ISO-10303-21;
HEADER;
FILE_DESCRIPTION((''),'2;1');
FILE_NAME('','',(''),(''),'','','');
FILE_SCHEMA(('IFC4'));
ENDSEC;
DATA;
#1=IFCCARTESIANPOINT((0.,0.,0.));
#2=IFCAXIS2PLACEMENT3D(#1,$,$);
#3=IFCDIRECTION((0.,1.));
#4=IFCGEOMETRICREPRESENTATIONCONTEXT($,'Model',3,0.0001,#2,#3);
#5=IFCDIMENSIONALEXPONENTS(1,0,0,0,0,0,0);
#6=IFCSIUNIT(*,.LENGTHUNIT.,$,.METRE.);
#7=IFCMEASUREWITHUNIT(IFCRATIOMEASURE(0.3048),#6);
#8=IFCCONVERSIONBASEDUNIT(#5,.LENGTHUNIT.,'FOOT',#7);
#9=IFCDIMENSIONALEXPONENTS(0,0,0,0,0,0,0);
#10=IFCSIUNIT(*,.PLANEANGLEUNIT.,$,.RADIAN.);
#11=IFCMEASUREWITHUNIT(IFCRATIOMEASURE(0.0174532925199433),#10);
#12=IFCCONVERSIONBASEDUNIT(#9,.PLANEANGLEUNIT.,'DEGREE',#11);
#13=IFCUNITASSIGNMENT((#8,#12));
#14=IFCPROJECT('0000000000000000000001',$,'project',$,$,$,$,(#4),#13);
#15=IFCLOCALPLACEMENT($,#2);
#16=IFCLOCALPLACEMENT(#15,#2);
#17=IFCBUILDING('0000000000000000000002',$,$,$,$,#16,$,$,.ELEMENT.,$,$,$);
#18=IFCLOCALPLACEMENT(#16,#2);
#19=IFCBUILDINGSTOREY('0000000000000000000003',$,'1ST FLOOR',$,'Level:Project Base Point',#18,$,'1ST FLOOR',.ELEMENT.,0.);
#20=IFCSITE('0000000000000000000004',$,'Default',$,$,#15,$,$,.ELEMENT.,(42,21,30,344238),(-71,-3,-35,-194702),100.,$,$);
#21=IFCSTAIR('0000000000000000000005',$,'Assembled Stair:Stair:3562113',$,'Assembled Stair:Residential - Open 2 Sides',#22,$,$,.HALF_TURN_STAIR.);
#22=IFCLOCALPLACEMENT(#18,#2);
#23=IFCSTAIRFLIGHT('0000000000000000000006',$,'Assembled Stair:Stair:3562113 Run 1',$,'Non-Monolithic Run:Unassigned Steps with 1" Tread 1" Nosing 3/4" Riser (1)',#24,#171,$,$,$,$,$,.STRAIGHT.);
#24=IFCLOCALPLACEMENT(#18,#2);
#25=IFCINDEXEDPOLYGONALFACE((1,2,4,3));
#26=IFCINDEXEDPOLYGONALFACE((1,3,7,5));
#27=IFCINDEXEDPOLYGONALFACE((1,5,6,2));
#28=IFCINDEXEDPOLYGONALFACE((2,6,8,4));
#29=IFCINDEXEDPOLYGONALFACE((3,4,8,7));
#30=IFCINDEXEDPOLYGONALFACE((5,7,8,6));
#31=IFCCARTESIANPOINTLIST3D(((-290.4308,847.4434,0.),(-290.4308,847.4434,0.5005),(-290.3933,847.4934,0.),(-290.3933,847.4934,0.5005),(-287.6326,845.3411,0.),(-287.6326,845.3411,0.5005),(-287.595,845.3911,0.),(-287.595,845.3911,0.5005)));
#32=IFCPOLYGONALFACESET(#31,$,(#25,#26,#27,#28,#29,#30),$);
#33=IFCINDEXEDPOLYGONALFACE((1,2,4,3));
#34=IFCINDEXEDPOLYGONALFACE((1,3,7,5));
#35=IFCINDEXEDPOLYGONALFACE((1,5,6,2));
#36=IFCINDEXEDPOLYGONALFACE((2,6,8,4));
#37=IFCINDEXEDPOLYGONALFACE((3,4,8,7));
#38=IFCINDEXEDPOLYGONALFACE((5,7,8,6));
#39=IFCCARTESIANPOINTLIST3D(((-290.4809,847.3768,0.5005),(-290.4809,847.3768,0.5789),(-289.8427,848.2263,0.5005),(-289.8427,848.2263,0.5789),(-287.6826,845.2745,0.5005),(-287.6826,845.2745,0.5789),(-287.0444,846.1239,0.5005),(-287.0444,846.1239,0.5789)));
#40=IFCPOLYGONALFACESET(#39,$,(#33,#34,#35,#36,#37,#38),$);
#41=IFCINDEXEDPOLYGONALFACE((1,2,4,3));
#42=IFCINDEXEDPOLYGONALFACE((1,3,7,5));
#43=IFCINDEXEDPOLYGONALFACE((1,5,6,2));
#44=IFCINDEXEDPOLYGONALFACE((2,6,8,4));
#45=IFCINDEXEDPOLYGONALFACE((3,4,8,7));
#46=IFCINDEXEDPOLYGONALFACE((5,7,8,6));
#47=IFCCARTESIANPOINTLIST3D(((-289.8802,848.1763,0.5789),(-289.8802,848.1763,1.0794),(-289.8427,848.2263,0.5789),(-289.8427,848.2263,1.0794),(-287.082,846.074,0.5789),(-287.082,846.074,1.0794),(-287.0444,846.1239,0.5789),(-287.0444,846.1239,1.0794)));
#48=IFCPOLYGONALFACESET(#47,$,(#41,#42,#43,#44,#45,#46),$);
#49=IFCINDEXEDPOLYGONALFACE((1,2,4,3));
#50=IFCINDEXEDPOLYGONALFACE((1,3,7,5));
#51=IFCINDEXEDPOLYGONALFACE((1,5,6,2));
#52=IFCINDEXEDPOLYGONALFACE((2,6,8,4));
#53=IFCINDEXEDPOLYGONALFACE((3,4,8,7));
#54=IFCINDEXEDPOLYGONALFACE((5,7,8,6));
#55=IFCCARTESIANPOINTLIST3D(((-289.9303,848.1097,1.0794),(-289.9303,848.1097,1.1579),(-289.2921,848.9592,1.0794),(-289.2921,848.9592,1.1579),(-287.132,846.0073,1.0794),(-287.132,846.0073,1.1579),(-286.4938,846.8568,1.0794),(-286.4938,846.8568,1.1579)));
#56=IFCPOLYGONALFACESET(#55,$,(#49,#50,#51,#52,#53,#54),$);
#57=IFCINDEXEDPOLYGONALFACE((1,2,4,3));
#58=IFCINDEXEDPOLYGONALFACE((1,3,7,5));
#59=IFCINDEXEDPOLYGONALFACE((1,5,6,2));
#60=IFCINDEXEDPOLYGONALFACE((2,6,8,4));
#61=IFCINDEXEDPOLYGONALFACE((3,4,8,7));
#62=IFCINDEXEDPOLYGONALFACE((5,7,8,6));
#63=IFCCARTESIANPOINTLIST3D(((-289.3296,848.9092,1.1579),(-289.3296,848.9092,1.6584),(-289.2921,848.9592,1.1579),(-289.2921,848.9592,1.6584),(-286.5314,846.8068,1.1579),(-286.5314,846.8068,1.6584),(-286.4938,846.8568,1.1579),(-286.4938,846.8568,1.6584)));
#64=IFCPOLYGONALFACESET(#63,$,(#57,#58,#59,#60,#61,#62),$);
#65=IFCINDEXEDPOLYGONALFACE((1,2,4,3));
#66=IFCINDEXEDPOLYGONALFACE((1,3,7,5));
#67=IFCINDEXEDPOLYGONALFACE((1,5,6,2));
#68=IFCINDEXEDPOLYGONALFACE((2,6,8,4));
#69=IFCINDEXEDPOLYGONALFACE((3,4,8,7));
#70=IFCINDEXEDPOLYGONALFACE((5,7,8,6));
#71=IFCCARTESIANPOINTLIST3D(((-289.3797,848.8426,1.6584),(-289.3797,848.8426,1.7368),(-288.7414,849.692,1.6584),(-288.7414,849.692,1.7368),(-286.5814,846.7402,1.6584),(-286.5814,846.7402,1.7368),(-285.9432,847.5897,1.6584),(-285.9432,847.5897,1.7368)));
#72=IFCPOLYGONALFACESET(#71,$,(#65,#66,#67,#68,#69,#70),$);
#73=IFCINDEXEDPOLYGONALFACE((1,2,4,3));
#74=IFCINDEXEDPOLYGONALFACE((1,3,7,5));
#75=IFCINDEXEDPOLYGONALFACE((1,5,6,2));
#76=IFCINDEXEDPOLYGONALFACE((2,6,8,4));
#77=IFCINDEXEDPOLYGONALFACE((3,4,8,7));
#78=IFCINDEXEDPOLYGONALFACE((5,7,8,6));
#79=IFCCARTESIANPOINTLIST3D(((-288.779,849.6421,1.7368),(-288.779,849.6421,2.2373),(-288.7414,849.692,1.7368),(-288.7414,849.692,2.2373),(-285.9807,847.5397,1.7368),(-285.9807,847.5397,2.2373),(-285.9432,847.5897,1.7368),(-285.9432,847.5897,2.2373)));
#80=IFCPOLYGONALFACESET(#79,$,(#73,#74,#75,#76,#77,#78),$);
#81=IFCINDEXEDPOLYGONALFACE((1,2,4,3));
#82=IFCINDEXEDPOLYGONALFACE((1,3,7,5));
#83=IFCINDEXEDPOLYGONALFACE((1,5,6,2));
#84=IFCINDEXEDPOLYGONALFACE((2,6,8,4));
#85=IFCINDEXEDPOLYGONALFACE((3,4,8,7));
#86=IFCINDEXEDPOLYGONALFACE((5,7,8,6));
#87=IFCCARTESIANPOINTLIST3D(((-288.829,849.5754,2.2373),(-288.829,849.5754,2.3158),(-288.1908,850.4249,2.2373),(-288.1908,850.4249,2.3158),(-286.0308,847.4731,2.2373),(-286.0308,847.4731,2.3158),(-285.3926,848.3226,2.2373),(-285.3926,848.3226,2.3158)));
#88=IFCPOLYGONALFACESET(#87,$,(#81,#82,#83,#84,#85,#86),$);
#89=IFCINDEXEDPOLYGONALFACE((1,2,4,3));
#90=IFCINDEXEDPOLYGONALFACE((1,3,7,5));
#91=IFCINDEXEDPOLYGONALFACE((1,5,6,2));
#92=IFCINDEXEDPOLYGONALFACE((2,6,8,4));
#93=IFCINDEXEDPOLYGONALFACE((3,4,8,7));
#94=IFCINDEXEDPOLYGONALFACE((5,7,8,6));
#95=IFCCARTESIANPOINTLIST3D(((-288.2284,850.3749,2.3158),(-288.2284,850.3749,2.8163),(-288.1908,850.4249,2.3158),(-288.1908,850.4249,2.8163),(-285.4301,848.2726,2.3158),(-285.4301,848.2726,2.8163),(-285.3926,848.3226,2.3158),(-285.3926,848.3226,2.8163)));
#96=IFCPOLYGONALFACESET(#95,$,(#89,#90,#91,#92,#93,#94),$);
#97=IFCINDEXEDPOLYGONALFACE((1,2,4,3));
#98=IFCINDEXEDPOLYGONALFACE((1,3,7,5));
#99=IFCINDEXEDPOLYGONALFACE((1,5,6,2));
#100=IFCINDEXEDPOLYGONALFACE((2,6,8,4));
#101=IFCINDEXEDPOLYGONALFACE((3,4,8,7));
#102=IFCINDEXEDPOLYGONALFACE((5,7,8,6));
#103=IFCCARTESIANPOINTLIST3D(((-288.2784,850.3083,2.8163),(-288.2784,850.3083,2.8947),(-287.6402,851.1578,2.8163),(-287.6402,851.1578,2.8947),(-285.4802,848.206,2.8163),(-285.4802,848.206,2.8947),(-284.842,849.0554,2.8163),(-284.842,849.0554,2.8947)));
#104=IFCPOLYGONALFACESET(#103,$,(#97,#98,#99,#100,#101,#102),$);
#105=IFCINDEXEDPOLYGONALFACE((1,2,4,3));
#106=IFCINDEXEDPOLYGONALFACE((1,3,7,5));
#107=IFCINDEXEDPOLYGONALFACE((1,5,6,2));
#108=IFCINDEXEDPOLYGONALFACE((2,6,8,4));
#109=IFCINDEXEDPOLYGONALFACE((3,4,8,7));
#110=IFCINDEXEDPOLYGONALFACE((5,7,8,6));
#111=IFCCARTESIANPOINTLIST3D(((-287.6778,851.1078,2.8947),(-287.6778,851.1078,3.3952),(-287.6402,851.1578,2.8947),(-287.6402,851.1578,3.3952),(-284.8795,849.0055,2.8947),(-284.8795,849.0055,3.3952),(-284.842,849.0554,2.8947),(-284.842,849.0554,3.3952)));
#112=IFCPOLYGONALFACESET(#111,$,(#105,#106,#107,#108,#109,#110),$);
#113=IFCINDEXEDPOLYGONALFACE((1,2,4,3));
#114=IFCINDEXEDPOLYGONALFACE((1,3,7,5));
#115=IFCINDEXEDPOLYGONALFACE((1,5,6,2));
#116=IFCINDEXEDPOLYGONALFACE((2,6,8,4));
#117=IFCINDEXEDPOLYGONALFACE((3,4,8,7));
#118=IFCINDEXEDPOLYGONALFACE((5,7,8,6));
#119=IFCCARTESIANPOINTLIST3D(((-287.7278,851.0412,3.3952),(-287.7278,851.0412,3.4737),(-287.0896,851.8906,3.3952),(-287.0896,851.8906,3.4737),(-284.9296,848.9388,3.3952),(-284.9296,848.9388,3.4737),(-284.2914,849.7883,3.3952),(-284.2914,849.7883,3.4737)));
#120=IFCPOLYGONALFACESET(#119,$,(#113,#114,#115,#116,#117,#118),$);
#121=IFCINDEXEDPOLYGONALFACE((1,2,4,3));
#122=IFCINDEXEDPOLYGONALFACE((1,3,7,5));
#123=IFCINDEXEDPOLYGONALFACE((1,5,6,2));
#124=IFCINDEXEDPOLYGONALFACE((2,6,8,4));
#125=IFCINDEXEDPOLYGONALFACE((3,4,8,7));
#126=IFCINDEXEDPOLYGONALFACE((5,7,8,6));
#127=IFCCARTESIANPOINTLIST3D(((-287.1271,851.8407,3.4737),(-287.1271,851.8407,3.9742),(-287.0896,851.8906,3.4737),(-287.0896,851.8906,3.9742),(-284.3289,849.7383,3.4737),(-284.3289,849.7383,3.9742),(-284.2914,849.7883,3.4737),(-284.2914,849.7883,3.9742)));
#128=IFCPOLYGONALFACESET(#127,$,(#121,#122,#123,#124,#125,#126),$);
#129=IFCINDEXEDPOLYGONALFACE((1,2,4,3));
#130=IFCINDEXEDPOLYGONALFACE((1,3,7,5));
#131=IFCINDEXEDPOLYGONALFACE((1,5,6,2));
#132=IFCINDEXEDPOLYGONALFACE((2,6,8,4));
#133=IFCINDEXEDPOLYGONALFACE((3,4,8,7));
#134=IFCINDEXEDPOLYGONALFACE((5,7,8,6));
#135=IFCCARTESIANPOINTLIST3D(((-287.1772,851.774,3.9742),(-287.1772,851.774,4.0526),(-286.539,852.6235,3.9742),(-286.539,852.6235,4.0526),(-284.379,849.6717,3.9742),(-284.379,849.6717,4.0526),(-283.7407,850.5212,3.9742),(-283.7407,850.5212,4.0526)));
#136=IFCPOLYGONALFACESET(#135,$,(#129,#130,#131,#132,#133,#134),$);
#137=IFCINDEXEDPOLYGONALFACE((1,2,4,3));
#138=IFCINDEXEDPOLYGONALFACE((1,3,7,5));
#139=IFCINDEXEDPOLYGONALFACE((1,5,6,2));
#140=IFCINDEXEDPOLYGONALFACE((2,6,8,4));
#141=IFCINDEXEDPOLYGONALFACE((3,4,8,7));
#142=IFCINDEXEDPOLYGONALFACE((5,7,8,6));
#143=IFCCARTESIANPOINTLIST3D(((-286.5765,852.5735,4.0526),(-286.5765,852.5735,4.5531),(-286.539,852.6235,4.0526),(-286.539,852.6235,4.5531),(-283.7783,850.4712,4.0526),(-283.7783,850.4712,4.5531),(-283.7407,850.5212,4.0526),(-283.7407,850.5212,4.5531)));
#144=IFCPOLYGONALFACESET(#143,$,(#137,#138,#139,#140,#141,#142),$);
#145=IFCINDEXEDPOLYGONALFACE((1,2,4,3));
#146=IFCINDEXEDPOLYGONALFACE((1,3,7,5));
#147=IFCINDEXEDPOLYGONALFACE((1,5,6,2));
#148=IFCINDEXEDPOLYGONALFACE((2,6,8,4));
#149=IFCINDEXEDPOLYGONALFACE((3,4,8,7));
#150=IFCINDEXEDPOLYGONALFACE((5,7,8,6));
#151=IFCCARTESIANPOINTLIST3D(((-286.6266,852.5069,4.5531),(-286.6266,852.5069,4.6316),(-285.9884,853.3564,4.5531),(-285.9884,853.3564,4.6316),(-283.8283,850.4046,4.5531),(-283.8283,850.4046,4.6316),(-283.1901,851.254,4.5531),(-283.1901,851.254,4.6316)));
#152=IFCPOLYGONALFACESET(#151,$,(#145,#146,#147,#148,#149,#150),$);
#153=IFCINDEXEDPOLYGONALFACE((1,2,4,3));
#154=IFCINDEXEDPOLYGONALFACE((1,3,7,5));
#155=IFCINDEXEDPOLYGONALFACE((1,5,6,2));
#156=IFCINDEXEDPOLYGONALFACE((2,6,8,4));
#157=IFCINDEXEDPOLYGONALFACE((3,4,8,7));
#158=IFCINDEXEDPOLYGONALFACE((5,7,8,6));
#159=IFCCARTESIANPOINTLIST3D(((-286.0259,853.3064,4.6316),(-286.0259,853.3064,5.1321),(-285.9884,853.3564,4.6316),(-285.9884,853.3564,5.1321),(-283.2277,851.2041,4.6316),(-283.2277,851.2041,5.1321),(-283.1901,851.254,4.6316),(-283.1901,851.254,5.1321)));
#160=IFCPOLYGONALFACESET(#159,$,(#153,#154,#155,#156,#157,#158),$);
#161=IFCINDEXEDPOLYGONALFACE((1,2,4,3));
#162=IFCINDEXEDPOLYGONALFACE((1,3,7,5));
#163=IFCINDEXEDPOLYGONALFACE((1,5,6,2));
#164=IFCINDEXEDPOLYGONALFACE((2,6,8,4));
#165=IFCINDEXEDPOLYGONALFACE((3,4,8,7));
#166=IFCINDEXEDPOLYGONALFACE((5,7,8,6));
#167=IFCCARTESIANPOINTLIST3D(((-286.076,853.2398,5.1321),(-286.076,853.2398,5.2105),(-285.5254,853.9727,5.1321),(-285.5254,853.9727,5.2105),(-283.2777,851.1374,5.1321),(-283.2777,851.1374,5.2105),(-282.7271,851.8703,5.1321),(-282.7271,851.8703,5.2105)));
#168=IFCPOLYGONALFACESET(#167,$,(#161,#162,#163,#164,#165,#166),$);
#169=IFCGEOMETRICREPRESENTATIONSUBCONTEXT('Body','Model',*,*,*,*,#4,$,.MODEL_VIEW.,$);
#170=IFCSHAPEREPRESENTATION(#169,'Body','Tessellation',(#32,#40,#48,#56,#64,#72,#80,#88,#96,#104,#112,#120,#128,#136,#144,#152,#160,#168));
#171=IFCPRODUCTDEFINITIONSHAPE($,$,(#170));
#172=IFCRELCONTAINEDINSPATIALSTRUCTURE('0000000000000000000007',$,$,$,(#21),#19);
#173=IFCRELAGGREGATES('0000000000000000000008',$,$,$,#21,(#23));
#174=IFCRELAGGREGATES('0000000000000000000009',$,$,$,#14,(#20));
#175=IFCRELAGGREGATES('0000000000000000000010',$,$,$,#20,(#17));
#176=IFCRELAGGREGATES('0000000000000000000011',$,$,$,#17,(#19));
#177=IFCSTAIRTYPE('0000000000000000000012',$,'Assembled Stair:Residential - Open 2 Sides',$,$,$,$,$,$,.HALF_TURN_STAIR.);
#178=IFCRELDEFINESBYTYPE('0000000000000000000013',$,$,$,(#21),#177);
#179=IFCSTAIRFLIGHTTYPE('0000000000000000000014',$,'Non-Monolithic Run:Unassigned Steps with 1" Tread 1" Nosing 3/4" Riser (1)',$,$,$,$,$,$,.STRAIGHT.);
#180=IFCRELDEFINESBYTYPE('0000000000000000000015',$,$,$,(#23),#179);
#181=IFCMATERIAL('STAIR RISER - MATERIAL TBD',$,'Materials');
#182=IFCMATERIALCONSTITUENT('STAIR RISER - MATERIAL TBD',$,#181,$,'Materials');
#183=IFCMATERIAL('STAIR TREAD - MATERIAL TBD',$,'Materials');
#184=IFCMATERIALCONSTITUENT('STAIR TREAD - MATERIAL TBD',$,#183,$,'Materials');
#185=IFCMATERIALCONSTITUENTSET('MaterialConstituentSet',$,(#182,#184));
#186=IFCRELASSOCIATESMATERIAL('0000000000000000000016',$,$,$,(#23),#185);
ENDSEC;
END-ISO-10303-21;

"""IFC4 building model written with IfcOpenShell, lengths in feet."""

from ifc_helpers import new_model, entity, si_unit, converted_unit, direction, frame, frame_2d, origin, origin_2d_with_axis, place, context, subcontext, project, spatial, rectangle, extrude, material, constituent, constituent_set, type_object, element, aggregate, save


model = new_model("IFC4")

# Units and contexts
model_context = context("Model", 3, precision=0.0001, world=origin(), true_north=direction((0.0, 1.0)))
body_context = subcontext(model_context, "Body", "Model", "MODEL_VIEW")
ifc_project = project(units=[converted_unit("LENGTHUNIT", "FOOT", entity("IfcRatioMeasure", 0.3048), si_unit("LENGTHUNIT", "METRE"), dimensions=[1, 0, 0, 0, 0, 0, 0]), converted_unit("PLANEANGLEUNIT", "DEGREE", entity("IfcRatioMeasure", 0.0174532925199433), si_unit("PLANEANGLEUNIT", "RADIAN"), dimensions=[0, 0, 0, 0, 0, 0, 0])], contexts=[model_context])

# Site, building, storey
site_placement = place(None, origin())
site = spatial("IfcSite", under=ifc_project, at=site_placement, Name="Default", CompositionType="ELEMENT", RefLatitude=(42, 21, 30, 344238), RefLongitude=(-71, -3, -35, -194702), RefElevation=100.0)
building_placement = place(site_placement, origin())
building = spatial("IfcBuilding", under=site, at=building_placement, CompositionType="ELEMENT")
storey_placement = place(building_placement, origin())
storey = spatial("IfcBuildingStorey", under=building, at=storey_placement, Name="1ST FLOOR", ObjectType="Level:Project Base Point", LongName="1ST FLOOR", CompositionType="ELEMENT", Elevation=0.0)

# Stair
stair_type = type_object("IfcStairType", Name="Assembled Stair:Residential - Open 2 Sides", PredefinedType="HALF_TURN_STAIR")
stair_placement = place(storey_placement, origin())
stair = element("IfcStair", 1, at=stair_placement, inside=storey, type_object=stair_type, Name="Assembled Stair:Stair:3562113", ObjectType="Assembled Stair:Residential - Open 2 Sides", PredefinedType="HALF_TURN_STAIR")
ifc_material_1 = material(Name="STAIR TREAD - MATERIAL TBD", Category="Materials")

# Stair flight
ifc_material_2 = material(Name="STAIR RISER - MATERIAL TBD", Category="Materials")
ifc_constituent_1 = constituent(ifc_material_2, Name="STAIR RISER - MATERIAL TBD", Category="Materials")
ifc_constituent_2 = constituent(ifc_material_1, Name="STAIR TREAD - MATERIAL TBD", Category="Materials")
ifc_constituent_set_1 = constituent_set(constituents=[ifc_constituent_1, ifc_constituent_2], Name="MaterialConstituentSet")
stair_flight_type_1 = type_object("IfcStairFlightType", Name="Non-Monolithic Run:Unassigned Steps with 1\" Tread 1\" Nosing 3/4\" Riser (1)", PredefinedType="STRAIGHT")
stair_flight_1_placement = place(stair_placement, frame((-290.4809, 845.2745, 0.0)))
stair_flight_1 = element("IfcStairFlight", 2, at=stair_flight_1_placement, type_object=stair_flight_type_1, material=ifc_constituent_set_1, Name="Assembled Stair:Stair:3562113 Run 1", ObjectType="Non-Monolithic Run:Unassigned Steps with 1\" Tread 1\" Nosing 3/4\" Riser (1)", PredefinedType="STRAIGHT", context=body_context, shape_type="SweptSolid", body=[
    extrude(rectangle(XDim=3.5, YDim=0.0625, at=frame_2d((0.0, 0.0), x_axis=(1.0, 0.0))), frame((1.4679, 1.1428, 0.0), z_axis=(0.0, 0.0, 1.0), x_axis=(-0.799497, 0.60067, 0.0)), (0.0, 0.0, 1.0), 0.5005),
    extrude(rectangle(XDim=1.0625, YDim=3.5, at=frame_2d((0.0, 0.0), x_axis=(1.0, 0.0))), frame((1.7182, 1.4759, 0.5005), z_axis=(0.0, 0.0, 1.0), x_axis=(-0.60067, -0.799497, 0.0)), (0.0, 0.0, 1.0), 0.0785),
    extrude(rectangle(XDim=3.5, YDim=0.0625, at=origin_2d_with_axis()), frame((2.0186, 1.8757, 0.5789), z_axis=(0.0, 0.0, 1.0), x_axis=(-0.799497, 0.60067, 0.0)), (0.0, 0.0, 1.0), 0.5005),
    extrude(rectangle(XDim=1.0625, YDim=3.5, at=origin_2d_with_axis()), frame((2.2688, 2.2088, 1.0794), z_axis=(0.0, 0.0, 1.0), x_axis=(-0.60067, -0.799497, 0.0)), (0.0, 0.0, 1.0), 0.0785),
    extrude(rectangle(XDim=3.5, YDim=0.0625, at=origin_2d_with_axis()), frame((2.5692, 2.6085, 1.1579), z_axis=(0.0, 0.0, 1.0), x_axis=(-0.799497, 0.60067, 0.0)), (0.0, 0.0, 1.0), 0.5005),
    extrude(rectangle(XDim=1.0625, YDim=3.5, at=origin_2d_with_axis()), frame((2.8195, 2.9416, 1.6584), z_axis=(0.0, 0.0, 1.0), x_axis=(-0.60067, -0.799497, 0.0)), (0.0, 0.0, 1.0), 0.0785),
    extrude(rectangle(XDim=3.5, YDim=0.0625, at=origin_2d_with_axis()), frame((3.1198, 3.3414, 1.7368), z_axis=(0.0, 0.0, 1.0), x_axis=(-0.799497, 0.60067, 0.0)), (0.0, 0.0, 1.0), 0.5005),
    extrude(rectangle(XDim=1.0625, YDim=3.5, at=origin_2d_with_axis()), frame((3.3701, 3.6745, 2.2373), z_axis=(0.0, 0.0, 1.0), x_axis=(-0.60067, -0.799497, 0.0)), (0.0, 0.0, 1.0), 0.0785),
    extrude(rectangle(XDim=3.5, YDim=0.0625, at=origin_2d_with_axis()), frame((3.6704, 4.0743, 2.3158), z_axis=(0.0, 0.0, 1.0), x_axis=(-0.799497, 0.60067, 0.0)), (0.0, 0.0, 1.0), 0.5005),
    extrude(rectangle(XDim=1.0625, YDim=3.5, at=origin_2d_with_axis()), frame((3.9207, 4.4074, 2.8163), z_axis=(0.0, 0.0, 1.0), x_axis=(-0.60067, -0.799497, 0.0)), (0.0, 0.0, 1.0), 0.0785),
    extrude(rectangle(XDim=3.5, YDim=0.0625, at=origin_2d_with_axis()), frame((4.221, 4.8071, 2.8947), z_axis=(0.0, 0.0, 1.0), x_axis=(-0.799497, 0.60067, 0.0)), (0.0, 0.0, 1.0), 0.5005),
    extrude(rectangle(XDim=1.0625, YDim=3.5, at=origin_2d_with_axis()), frame((4.4713, 5.1403, 3.3952), z_axis=(0.0, 0.0, 1.0), x_axis=(-0.60067, -0.799497, 0.0)), (0.0, 0.0, 1.0), 0.0785),
    extrude(rectangle(XDim=3.5, YDim=0.0625, at=origin_2d_with_axis()), frame((4.7716, 5.54, 3.4737), z_axis=(0.0, 0.0, 1.0), x_axis=(-0.799497, 0.60067, 0.0)), (0.0, 0.0, 1.0), 0.5005),
    extrude(rectangle(XDim=1.0625, YDim=3.5, at=origin_2d_with_axis()), frame((5.0219, 5.8731, 3.9742), z_axis=(0.0, 0.0, 1.0), x_axis=(-0.60067, -0.799497, 0.0)), (0.0, 0.0, 1.0), 0.0785),
    extrude(rectangle(XDim=3.5, YDim=0.0625, at=origin_2d_with_axis()), frame((5.3222, 6.2729, 4.0526), z_axis=(0.0, 0.0, 1.0), x_axis=(-0.799497, 0.60067, 0.0)), (0.0, 0.0, 1.0), 0.5005),
    extrude(rectangle(XDim=1.0625, YDim=3.5, at=origin_2d_with_axis()), frame((5.5725, 6.606, 4.5531), z_axis=(0.0, 0.0, 1.0), x_axis=(-0.60067, -0.799497, 0.0)), (0.0, 0.0, 1.0), 0.0785),
    extrude(rectangle(XDim=3.5, YDim=0.0625, at=origin_2d_with_axis()), frame((5.8729, 7.0058, 4.6316), z_axis=(0.0, 0.0, 1.0), x_axis=(-0.799497, 0.60067, 0.0)), (0.0, 0.0, 1.0), 0.5005),
    extrude(rectangle(XDim=0.9167, YDim=3.5, at=frame_2d((0.0, 0.0), x_axis=(1.0, 0.0))), frame((6.0793, 7.2806, 5.1321), z_axis=(0.0, 0.0, 1.0), x_axis=(-0.60067, -0.799497, 0.0)), (0.0, 0.0, 1.0), 0.0785),
])
aggregate(stair, [stair_flight_1])

save(model, "model.ifc")
